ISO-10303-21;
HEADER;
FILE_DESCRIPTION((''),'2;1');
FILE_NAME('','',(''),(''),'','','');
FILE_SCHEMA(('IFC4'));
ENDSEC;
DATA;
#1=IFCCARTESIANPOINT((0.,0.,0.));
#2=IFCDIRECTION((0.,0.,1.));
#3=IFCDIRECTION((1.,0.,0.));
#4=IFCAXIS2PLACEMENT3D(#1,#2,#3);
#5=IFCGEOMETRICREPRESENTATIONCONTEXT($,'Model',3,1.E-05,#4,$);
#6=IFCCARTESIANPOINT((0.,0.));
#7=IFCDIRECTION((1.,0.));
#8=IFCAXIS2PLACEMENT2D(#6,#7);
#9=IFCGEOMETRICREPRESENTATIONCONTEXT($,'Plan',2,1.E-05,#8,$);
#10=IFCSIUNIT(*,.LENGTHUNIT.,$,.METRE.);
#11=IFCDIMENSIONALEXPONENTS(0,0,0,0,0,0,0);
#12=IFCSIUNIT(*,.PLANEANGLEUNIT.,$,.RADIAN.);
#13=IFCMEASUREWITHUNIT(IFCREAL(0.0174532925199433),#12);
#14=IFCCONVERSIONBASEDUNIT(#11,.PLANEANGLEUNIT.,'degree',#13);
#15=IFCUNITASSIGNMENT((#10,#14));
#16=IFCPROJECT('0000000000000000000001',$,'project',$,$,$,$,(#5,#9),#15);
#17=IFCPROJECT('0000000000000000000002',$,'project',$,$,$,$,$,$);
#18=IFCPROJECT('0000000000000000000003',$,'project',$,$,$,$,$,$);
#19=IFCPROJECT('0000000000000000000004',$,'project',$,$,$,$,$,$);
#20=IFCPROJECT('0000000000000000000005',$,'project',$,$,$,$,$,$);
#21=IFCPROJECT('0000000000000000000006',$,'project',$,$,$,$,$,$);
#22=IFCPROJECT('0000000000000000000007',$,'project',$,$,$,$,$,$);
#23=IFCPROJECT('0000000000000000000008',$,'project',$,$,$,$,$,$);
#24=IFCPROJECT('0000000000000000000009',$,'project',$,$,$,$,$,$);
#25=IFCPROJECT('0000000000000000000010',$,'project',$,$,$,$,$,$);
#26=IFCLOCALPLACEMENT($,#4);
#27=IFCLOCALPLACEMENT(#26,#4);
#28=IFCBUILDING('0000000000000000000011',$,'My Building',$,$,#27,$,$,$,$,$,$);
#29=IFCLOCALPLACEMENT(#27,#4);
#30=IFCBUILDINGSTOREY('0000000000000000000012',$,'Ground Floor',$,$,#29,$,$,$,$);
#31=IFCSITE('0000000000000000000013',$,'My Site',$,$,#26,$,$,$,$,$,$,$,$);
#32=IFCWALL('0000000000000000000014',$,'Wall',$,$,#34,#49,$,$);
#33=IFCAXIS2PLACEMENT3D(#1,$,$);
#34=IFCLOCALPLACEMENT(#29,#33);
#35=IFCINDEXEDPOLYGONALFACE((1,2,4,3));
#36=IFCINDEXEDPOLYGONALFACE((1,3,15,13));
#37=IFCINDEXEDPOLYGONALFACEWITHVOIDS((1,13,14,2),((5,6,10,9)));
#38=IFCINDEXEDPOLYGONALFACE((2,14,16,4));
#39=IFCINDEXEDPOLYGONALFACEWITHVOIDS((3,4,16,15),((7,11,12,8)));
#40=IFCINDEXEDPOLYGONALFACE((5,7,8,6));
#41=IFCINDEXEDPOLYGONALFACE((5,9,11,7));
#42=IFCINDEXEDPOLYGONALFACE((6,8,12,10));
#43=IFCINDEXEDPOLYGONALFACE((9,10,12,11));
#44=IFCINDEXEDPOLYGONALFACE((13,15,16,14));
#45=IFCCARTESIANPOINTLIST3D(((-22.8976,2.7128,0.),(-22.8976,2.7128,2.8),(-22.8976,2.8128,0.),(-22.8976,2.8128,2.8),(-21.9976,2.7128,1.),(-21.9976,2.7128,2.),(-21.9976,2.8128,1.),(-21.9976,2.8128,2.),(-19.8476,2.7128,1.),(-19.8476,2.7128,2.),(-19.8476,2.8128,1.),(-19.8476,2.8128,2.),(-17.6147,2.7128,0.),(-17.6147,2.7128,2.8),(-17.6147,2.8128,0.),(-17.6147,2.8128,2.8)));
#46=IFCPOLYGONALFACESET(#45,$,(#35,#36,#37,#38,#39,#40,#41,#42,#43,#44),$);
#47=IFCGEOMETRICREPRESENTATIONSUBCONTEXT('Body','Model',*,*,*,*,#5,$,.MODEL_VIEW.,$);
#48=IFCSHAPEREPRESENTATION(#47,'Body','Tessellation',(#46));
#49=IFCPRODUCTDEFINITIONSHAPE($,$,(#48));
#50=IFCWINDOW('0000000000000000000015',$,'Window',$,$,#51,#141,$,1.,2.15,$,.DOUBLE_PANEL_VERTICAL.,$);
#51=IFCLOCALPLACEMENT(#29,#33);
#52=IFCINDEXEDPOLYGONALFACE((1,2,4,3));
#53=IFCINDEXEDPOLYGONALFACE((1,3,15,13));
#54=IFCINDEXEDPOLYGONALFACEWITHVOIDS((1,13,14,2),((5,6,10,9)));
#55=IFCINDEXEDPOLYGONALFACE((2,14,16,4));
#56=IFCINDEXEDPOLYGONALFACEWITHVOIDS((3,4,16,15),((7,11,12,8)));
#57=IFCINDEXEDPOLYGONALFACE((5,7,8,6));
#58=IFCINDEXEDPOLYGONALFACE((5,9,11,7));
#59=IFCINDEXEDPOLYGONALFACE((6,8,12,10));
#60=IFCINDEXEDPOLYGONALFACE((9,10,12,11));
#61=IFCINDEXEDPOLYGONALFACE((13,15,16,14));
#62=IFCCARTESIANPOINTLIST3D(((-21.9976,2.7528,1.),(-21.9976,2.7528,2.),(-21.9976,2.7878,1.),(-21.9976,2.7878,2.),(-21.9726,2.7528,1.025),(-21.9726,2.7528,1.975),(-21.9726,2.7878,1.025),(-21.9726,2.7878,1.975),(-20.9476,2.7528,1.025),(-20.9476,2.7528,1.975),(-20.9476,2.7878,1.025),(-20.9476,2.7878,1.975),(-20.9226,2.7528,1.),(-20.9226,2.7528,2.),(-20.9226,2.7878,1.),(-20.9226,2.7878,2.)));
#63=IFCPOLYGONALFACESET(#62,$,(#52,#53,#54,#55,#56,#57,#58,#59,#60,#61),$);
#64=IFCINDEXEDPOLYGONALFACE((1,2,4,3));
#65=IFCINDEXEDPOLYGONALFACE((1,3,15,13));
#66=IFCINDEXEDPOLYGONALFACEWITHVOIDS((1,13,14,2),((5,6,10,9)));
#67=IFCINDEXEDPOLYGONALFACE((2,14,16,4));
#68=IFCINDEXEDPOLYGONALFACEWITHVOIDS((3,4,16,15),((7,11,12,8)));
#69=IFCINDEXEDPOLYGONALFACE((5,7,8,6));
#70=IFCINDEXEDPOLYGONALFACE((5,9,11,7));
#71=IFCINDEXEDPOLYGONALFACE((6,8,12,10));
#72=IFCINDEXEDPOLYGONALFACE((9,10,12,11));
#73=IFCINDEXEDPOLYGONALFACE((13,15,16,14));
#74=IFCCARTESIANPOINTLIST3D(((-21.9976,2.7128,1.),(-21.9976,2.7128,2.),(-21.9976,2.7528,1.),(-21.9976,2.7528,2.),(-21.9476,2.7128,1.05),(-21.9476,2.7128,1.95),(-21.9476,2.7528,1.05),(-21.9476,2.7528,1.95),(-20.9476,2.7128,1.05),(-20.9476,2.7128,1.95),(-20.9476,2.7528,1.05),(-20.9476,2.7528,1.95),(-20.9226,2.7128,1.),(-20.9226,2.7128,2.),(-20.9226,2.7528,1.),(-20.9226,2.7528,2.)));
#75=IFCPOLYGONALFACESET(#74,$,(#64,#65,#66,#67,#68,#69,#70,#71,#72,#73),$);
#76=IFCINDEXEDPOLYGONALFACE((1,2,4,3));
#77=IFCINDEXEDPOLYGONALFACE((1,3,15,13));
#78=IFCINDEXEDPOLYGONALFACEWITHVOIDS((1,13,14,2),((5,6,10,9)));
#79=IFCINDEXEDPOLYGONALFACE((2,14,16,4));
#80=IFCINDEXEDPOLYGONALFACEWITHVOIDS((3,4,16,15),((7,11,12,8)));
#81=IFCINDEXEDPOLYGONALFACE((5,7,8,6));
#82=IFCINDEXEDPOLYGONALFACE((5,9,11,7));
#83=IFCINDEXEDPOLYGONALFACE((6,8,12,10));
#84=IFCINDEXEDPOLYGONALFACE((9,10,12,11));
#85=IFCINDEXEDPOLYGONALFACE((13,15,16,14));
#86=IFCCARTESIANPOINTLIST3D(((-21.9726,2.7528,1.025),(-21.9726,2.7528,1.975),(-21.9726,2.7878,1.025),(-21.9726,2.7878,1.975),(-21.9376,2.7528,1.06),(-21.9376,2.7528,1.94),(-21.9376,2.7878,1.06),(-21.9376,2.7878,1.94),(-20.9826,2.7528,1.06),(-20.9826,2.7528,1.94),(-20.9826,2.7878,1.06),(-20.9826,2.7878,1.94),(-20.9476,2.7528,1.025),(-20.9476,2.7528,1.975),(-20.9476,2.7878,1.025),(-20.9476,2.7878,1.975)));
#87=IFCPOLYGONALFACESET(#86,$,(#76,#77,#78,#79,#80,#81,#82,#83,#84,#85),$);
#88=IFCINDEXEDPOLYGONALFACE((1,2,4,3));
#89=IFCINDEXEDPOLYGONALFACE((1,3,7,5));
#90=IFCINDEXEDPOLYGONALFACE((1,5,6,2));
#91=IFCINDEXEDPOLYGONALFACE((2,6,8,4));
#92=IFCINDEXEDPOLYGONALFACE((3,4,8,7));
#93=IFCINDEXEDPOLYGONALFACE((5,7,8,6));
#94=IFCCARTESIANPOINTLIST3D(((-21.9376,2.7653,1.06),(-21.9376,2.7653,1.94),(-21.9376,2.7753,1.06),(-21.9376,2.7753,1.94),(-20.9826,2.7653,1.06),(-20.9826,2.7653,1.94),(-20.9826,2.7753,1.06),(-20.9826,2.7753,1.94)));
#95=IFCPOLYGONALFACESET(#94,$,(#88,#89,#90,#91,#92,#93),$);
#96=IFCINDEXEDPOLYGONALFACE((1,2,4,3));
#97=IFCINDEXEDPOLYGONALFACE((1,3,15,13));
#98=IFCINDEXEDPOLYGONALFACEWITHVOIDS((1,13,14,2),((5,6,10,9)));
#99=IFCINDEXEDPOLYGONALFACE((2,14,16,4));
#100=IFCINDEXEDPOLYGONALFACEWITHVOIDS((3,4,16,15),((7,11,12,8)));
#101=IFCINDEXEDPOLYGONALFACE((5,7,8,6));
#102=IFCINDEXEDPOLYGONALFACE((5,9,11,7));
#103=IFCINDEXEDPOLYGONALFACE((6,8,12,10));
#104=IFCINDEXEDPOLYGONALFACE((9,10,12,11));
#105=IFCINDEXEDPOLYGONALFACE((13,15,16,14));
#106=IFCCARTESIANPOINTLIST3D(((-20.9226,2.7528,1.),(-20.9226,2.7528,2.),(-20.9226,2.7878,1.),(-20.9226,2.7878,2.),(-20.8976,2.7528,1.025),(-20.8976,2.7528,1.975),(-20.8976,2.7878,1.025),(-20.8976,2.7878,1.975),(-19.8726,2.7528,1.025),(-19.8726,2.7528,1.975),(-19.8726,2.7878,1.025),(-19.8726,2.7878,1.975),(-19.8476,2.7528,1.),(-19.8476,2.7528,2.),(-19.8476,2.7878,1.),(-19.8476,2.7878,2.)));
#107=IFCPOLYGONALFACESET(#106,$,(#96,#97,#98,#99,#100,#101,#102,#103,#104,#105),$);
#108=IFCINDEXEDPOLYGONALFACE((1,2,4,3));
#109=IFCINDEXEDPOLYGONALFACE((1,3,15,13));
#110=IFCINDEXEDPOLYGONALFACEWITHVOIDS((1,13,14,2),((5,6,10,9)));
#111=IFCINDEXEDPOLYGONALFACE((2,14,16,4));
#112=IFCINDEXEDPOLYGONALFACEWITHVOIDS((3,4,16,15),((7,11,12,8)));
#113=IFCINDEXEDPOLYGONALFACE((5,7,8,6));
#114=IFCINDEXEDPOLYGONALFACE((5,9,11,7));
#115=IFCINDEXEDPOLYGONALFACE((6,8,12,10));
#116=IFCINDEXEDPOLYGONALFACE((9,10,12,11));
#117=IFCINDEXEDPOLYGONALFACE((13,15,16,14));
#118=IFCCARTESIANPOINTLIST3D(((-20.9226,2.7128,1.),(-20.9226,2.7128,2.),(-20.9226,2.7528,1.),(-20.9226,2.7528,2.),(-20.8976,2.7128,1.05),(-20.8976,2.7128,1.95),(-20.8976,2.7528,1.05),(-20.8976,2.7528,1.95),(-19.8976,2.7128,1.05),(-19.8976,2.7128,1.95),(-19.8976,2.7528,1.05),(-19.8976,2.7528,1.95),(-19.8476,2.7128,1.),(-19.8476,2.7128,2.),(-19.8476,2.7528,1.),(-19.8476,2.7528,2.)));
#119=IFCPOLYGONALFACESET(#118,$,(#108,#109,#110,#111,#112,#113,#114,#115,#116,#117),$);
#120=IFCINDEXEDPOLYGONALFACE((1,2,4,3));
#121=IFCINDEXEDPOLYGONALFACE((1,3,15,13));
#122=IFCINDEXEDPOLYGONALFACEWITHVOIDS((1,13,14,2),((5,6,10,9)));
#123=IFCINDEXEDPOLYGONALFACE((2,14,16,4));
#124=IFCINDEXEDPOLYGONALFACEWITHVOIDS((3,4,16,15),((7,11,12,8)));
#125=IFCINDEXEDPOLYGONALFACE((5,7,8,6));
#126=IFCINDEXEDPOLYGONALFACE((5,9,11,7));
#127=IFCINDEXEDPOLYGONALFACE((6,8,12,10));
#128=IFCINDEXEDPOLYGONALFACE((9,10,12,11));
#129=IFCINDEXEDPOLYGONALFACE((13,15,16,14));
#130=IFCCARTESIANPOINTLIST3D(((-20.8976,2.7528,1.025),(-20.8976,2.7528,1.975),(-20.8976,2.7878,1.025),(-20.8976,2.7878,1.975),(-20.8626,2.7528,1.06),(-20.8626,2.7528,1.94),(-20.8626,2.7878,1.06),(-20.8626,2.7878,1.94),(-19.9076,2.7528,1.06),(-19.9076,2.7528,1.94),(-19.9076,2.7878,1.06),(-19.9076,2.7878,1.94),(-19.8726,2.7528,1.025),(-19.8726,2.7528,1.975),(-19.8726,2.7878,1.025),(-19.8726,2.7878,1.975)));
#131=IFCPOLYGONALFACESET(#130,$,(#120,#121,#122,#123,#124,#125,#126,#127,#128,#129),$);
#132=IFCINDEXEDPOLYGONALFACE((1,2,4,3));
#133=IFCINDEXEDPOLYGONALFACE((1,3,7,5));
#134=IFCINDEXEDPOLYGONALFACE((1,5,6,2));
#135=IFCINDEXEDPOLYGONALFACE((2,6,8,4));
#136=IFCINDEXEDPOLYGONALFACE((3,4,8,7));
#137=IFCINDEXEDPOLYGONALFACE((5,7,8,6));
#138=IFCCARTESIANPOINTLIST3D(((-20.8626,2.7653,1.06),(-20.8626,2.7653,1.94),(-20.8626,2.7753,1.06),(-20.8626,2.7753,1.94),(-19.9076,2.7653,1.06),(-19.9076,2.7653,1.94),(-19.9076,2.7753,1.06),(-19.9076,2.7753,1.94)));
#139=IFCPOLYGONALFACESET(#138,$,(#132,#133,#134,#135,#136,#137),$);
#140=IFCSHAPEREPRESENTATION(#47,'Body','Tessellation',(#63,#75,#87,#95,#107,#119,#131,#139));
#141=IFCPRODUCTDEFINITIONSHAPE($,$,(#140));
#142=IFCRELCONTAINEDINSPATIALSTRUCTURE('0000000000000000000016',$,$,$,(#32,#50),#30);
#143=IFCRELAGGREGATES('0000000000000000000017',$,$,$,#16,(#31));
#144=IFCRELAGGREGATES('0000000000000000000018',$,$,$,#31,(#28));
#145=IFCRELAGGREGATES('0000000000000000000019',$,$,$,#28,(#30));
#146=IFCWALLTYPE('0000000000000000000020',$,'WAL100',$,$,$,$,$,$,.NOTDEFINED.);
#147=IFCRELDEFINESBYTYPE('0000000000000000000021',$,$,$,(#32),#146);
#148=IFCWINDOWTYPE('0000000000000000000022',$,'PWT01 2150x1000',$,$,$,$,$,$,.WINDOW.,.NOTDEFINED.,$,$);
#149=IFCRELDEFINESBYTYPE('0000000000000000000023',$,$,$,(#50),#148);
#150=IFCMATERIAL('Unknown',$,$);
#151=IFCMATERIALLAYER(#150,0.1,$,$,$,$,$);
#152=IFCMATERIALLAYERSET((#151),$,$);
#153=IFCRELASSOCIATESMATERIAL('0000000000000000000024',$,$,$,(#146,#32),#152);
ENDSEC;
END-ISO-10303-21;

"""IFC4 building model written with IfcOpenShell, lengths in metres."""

from ifc_helpers import new_model, entity, si_unit, converted_unit, frame, origin_with_axes, origin_2d_with_axis, place, context, subcontext, project, spatial, line, indexed_curve, outline, extrude, shape, source, transform, mapped, material, layer, layer_set, layer_usage, type_object, type_shapes, element, fill, save


model = new_model("IFC4")

# Units and contexts
model_context = context("Model", 3, precision=1e-05, world=origin_with_axes())
plan_context = context("Plan", 2, precision=1e-05, world=origin_2d_with_axis())
body_context_1 = subcontext(model_context, "Body", "Model", "MODEL_VIEW")
body_context_2 = subcontext(plan_context, "Body", "Plan", "PLAN_VIEW")
ifc_project_1 = project(units=[si_unit("LENGTHUNIT", "METRE"), converted_unit("PLANEANGLEUNIT", "degree", entity("IfcReal", 0.0174532925199433), si_unit("PLANEANGLEUNIT", "RADIAN"), dimensions=[0, 0, 0, 0, 0, 0, 0])], contexts=[model_context, plan_context])
ifc_project_2 = project()
ifc_project_3 = project()
ifc_project_4 = project()
ifc_project_5 = project()
ifc_project_6 = project()
ifc_project_7 = project()
ifc_project_8 = project()
ifc_project_9 = project()
ifc_project_10 = project()

# Site, building, storey
site_placement = place(None, origin_with_axes())
site = spatial("IfcSite", under=ifc_project_1, at=site_placement, Name="My Site")
building_placement = place(site_placement, origin_with_axes())
building = spatial("IfcBuilding", under=site, at=building_placement, Name="My Building")
storey_placement = place(building_placement, origin_with_axes())
storey = spatial("IfcBuildingStorey", under=building, at=storey_placement, Name="Ground Floor")

# Shared definitions
ifc_material = material(Name="Unknown")

# Shared definitions
ifc_layer_1 = layer(ifc_material, 0.1)
ifc_layer_set_1 = layer_set([ifc_layer_1])
wall_type = type_object("IfcWallType", Name="WAL100", PredefinedType="NOTDEFINED", material=ifc_layer_set_1)

# Wall, opening, window
ifc_layer_usage_1 = layer_usage(ifc_layer_set_1, "AXIS2", "POSITIVE", 0.0)
wall_1_placement = place(storey_placement, frame((-22.8976, 2.7128, 0.0), z_axis=(0.0, 0.0, 1.0), x_axis=(1.0, 0.0, 0.0)))
wall_1 = element("IfcWall", 1, at=wall_1_placement, inside=storey, type_object=wall_type, material=ifc_layer_usage_1, Name="Wall", context=body_context_1, shape_type="SweptSolid", body=[
    extrude(outline(indexed_curve([(0.0, 0.0), (0.0, 0.1), (5.2829, 0.1), (5.2829, 0.0), (0.0, 0.0)], self_intersect=False)), origin_with_axes(), (0.0, 0.0, 1.0), 2.8),
])
shared_shape_1 = source(origin_with_axes(), body_context_1, "Body", "SweptSolid", [
    extrude(outline(indexed_curve([(0.0, 0.0), (2.15, 0.0), (2.15, 1.0), (0.0, 1.0)], segments=[line(1, 2, 2, 3, 3, 4, 4, 1)])), frame((0.0, -0.1, 0.0), z_axis=(0.0, -1.0, 0.0), x_axis=(1.0, 0.0, 0.0)), (0.0, 0.0, -1.0), 0.3),
])
opening_1_placement = place(wall_1_placement, frame((0.9, 0.0, 1.0), z_axis=(0.0, 0.0, 1.0), x_axis=(1.0, 0.0, 0.0)))
opening_1 = element("IfcOpeningElement", 2, at=opening_1_placement, cuts=wall_1, PredefinedType="OPENING", context=body_context_1, shape_type="MappedRepresentation", body=[
    mapped(shared_shape_1, transform((0.0, 0.0, 0.0), x_axis=(1.0, 0.0, 0.0), y_axis=(0.0, 1.0, 0.0), z_axis=(0.0, 0.0, 1.0), scale=1.0)),
])
window_type_1 = type_object("IfcWindowType", Name="PWT01 2150x1000", PartitioningType="NOTDEFINED", PredefinedType="WINDOW")
shared_shape_2 = source(origin_with_axes(), body_context_1, "Body", "SweptSolid", [
    extrude(outline(indexed_curve([(0.0, 0.0), (1.075, 0.0), (1.075, 1.0), (0.0, 1.0)], segments=[line(1, 2, 2, 3, 3, 4, 4, 1)]), holes=[indexed_curve([(0.025, 0.025), (1.05, 0.025), (1.05, 0.975), (0.025, 0.975)], segments=[line(1, 2, 2, 3, 3, 4, 4, 1)])]), frame((0.0, 0.04, 0.0), z_axis=(0.0, -1.0, 0.0), x_axis=(1.0, 0.0, 0.0)), (0.0, 0.0, -1.0), 0.035),
    extrude(outline(indexed_curve([(0.0, 0.0), (1.075, 0.0), (1.075, 1.0), (0.0, 1.0)], segments=[line(1, 2, 2, 3, 3, 4, 4, 1)]), holes=[indexed_curve([(0.05, 0.05), (1.05, 0.05), (1.05, 0.95), (0.05, 0.95)], segments=[line(1, 2, 2, 3, 3, 4, 4, 1)])]), frame((0.0, 0.0, 0.0), z_axis=(0.0, -1.0, 0.0), x_axis=(1.0, 0.0, 0.0)), (0.0, 0.0, -1.0), 0.04),
    extrude(outline(indexed_curve([(0.0, 0.0), (1.025, 0.0), (1.025, 0.95), (0.0, 0.95)], segments=[line(1, 2, 2, 3, 3, 4, 4, 1)]), holes=[indexed_curve([(0.035, 0.035), (0.99, 0.035), (0.99, 0.915), (0.035, 0.915)], segments=[line(1, 2, 2, 3, 3, 4, 4, 1)])]), frame((0.025, 0.04, 0.025), z_axis=(0.0, -1.0, 0.0), x_axis=(1.0, 0.0, 0.0)), (0.0, 0.0, -1.0), 0.035),
    extrude(outline(indexed_curve([(0.035, 0.035), (0.99, 0.035), (0.99, 0.915), (0.035, 0.915)], segments=[line(1, 2, 2, 3, 3, 4, 4, 1)])), frame((0.025, 0.0525, 0.025), z_axis=(0.0, -1.0, 0.0), x_axis=(1.0, 0.0, 0.0)), (0.0, 0.0, -1.0), 0.01),
    extrude(outline(indexed_curve([(0.0, 0.0), (1.075, 0.0), (1.075, 1.0), (0.0, 1.0)], segments=[line(1, 2, 2, 3, 3, 4, 4, 1)]), holes=[indexed_curve([(0.025, 0.025), (1.05, 0.025), (1.05, 0.975), (0.025, 0.975)], segments=[line(1, 2, 2, 3, 3, 4, 4, 1)])]), frame((1.075, 0.04, 0.0), z_axis=(0.0, -1.0, 0.0), x_axis=(1.0, 0.0, 0.0)), (0.0, 0.0, -1.0), 0.035),
    extrude(outline(indexed_curve([(0.0, 0.0), (1.075, 0.0), (1.075, 1.0), (0.0, 1.0)], segments=[line(1, 2, 2, 3, 3, 4, 4, 1)]), holes=[indexed_curve([(0.025, 0.05), (1.025, 0.05), (1.025, 0.95), (0.025, 0.95)], segments=[line(1, 2, 2, 3, 3, 4, 4, 1)])]), frame((1.075, 0.0, 0.0), z_axis=(0.0, -1.0, 0.0), x_axis=(1.0, 0.0, 0.0)), (0.0, 0.0, -1.0), 0.04),
    extrude(outline(indexed_curve([(0.0, 0.0), (1.025, 0.0), (1.025, 0.95), (0.0, 0.95)], segments=[line(1, 2, 2, 3, 3, 4, 4, 1)]), holes=[indexed_curve([(0.035, 0.035), (0.99, 0.035), (0.99, 0.915), (0.035, 0.915)], segments=[line(1, 2, 2, 3, 3, 4, 4, 1)])]), frame((1.1, 0.04, 0.025), z_axis=(0.0, -1.0, 0.0), x_axis=(1.0, 0.0, 0.0)), (0.0, 0.0, -1.0), 0.035),
    extrude(outline(indexed_curve([(0.035, 0.035), (0.99, 0.035), (0.99, 0.915), (0.035, 0.915)], segments=[line(1, 2, 2, 3, 3, 4, 4, 1)])), frame((1.1, 0.0525, 0.025), z_axis=(0.0, -1.0, 0.0), x_axis=(1.0, 0.0, 0.0)), (0.0, 0.0, -1.0), 0.01),
])
shared_shape_3 = source(origin_with_axes(), body_context_2, "Body", "Curve2D", [
    entity("IfcIndexedPolyCurve", entity("IfcCartesianPointList2D", [[0.05, 0.0], [1.05, 0.0]]), [entity("IfcLineIndex", [1, 2])]),
    entity("IfcIndexedPolyCurve", entity("IfcCartesianPointList2D", [[0.0, 0.075], [0.025, 0.075], [0.025, 0.04], [0.05, 0.04], [0.05, 0.0], [0.0, 0.0]]), [entity("IfcLineIndex", [1, 2, 2, 3, 3, 4, 4, 5, 5, 6, 6, 1])]),
    entity("IfcIndexedPolyCurve", entity("IfcCartesianPointList2D", [[1.075, 0.075], [1.05, 0.075], [1.05, 0.0], [1.075, 0.0]]), [entity("IfcLineIndex", [1, 2, 2, 3, 3, 4])]),
    entity("IfcIndexedPolyCurve", entity("IfcCartesianPointList2D", [[0.025, 0.04], [0.06, 0.04], [0.06, 0.075], [0.025, 0.075]]), [entity("IfcLineIndex", [1, 2, 2, 3, 3, 4, 4, 1])]),
    entity("IfcIndexedPolyCurve", entity("IfcCartesianPointList2D", [[1.05, 0.04], [1.015, 0.04], [1.015, 0.075], [1.05, 0.075]]), [entity("IfcLineIndex", [1, 2, 2, 3, 3, 4, 4, 1])]),
    entity("IfcIndexedPolyCurve", entity("IfcCartesianPointList2D", [[0.06, 0.04], [1.015, 0.04]]), [entity("IfcLineIndex", [1, 2])]),
    entity("IfcIndexedPolyCurve", entity("IfcCartesianPointList2D", [[0.06, 0.075], [1.015, 0.075]]), [entity("IfcLineIndex", [1, 2])]),
    entity("IfcIndexedPolyCurve", entity("IfcCartesianPointList2D", [[0.06, 0.0575], [1.015, 0.0575]]), [entity("IfcLineIndex", [1, 2])]),
    entity("IfcIndexedPolyCurve", entity("IfcCartesianPointList2D", [[1.1, 0.0], [2.1, 0.0]]), [entity("IfcLineIndex", [1, 2])]),
    entity("IfcIndexedPolyCurve", entity("IfcCartesianPointList2D", [[1.075, 0.075], [1.1, 0.075], [1.1, 0.0], [1.075, 0.0]]), [entity("IfcLineIndex", [1, 2, 2, 3, 3, 4])]),
    entity("IfcIndexedPolyCurve", entity("IfcCartesianPointList2D", [[2.15, 0.075], [2.125, 0.075], [2.125, 0.04], [2.1, 0.04], [2.1, 0.0], [2.15, 0.0]]), [entity("IfcLineIndex", [1, 2, 2, 3, 3, 4, 4, 5, 5, 6, 6, 1])]),
    entity("IfcIndexedPolyCurve", entity("IfcCartesianPointList2D", [[1.1, 0.04], [1.135, 0.04], [1.135, 0.075], [1.1, 0.075]]), [entity("IfcLineIndex", [1, 2, 2, 3, 3, 4, 4, 1])]),
    entity("IfcIndexedPolyCurve", entity("IfcCartesianPointList2D", [[2.125, 0.04], [2.09, 0.04], [2.09, 0.075], [2.125, 0.075]]), [entity("IfcLineIndex", [1, 2, 2, 3, 3, 4, 4, 1])]),
    entity("IfcIndexedPolyCurve", entity("IfcCartesianPointList2D", [[1.135, 0.04], [2.09, 0.04]]), [entity("IfcLineIndex", [1, 2])]),
    entity("IfcIndexedPolyCurve", entity("IfcCartesianPointList2D", [[1.135, 0.075], [2.09, 0.075]]), [entity("IfcLineIndex", [1, 2])]),
    entity("IfcIndexedPolyCurve", entity("IfcCartesianPointList2D", [[1.135, 0.0575], [2.09, 0.0575]]), [entity("IfcLineIndex", [1, 2])]),
])
type_shapes(window_type_1, [shared_shape_2, shared_shape_3])
window_1_placement = place(opening_1_placement, origin_with_axes())
window_1 = element("IfcWindow", 3, at=window_1_placement, inside=storey, type_object=window_type_1, Name="Window", OverallHeight=1.0, OverallWidth=2.15, PartitioningType="DOUBLE_PANEL_VERTICAL", shapes=[
    shape(body_context_1, "Body", "MappedRepresentation", [mapped(shared_shape_2, transform((0.0, 0.0, 0.0), x_axis=(1.0, 0.0, 0.0), y_axis=(0.0, 1.0, 0.0), z_axis=(0.0, 0.0, 1.0), scale=1.0))]),
    shape(body_context_2, "Body", "MappedRepresentation", [mapped(shared_shape_3, transform((0.0, 0.0, 0.0), x_axis=(1.0, 0.0, 0.0), y_axis=(0.0, 1.0, 0.0), z_axis=(0.0, 0.0, 1.0), scale=1.0))]),
])
fill(opening_1, window_1)

save(model, "model.ifc")
